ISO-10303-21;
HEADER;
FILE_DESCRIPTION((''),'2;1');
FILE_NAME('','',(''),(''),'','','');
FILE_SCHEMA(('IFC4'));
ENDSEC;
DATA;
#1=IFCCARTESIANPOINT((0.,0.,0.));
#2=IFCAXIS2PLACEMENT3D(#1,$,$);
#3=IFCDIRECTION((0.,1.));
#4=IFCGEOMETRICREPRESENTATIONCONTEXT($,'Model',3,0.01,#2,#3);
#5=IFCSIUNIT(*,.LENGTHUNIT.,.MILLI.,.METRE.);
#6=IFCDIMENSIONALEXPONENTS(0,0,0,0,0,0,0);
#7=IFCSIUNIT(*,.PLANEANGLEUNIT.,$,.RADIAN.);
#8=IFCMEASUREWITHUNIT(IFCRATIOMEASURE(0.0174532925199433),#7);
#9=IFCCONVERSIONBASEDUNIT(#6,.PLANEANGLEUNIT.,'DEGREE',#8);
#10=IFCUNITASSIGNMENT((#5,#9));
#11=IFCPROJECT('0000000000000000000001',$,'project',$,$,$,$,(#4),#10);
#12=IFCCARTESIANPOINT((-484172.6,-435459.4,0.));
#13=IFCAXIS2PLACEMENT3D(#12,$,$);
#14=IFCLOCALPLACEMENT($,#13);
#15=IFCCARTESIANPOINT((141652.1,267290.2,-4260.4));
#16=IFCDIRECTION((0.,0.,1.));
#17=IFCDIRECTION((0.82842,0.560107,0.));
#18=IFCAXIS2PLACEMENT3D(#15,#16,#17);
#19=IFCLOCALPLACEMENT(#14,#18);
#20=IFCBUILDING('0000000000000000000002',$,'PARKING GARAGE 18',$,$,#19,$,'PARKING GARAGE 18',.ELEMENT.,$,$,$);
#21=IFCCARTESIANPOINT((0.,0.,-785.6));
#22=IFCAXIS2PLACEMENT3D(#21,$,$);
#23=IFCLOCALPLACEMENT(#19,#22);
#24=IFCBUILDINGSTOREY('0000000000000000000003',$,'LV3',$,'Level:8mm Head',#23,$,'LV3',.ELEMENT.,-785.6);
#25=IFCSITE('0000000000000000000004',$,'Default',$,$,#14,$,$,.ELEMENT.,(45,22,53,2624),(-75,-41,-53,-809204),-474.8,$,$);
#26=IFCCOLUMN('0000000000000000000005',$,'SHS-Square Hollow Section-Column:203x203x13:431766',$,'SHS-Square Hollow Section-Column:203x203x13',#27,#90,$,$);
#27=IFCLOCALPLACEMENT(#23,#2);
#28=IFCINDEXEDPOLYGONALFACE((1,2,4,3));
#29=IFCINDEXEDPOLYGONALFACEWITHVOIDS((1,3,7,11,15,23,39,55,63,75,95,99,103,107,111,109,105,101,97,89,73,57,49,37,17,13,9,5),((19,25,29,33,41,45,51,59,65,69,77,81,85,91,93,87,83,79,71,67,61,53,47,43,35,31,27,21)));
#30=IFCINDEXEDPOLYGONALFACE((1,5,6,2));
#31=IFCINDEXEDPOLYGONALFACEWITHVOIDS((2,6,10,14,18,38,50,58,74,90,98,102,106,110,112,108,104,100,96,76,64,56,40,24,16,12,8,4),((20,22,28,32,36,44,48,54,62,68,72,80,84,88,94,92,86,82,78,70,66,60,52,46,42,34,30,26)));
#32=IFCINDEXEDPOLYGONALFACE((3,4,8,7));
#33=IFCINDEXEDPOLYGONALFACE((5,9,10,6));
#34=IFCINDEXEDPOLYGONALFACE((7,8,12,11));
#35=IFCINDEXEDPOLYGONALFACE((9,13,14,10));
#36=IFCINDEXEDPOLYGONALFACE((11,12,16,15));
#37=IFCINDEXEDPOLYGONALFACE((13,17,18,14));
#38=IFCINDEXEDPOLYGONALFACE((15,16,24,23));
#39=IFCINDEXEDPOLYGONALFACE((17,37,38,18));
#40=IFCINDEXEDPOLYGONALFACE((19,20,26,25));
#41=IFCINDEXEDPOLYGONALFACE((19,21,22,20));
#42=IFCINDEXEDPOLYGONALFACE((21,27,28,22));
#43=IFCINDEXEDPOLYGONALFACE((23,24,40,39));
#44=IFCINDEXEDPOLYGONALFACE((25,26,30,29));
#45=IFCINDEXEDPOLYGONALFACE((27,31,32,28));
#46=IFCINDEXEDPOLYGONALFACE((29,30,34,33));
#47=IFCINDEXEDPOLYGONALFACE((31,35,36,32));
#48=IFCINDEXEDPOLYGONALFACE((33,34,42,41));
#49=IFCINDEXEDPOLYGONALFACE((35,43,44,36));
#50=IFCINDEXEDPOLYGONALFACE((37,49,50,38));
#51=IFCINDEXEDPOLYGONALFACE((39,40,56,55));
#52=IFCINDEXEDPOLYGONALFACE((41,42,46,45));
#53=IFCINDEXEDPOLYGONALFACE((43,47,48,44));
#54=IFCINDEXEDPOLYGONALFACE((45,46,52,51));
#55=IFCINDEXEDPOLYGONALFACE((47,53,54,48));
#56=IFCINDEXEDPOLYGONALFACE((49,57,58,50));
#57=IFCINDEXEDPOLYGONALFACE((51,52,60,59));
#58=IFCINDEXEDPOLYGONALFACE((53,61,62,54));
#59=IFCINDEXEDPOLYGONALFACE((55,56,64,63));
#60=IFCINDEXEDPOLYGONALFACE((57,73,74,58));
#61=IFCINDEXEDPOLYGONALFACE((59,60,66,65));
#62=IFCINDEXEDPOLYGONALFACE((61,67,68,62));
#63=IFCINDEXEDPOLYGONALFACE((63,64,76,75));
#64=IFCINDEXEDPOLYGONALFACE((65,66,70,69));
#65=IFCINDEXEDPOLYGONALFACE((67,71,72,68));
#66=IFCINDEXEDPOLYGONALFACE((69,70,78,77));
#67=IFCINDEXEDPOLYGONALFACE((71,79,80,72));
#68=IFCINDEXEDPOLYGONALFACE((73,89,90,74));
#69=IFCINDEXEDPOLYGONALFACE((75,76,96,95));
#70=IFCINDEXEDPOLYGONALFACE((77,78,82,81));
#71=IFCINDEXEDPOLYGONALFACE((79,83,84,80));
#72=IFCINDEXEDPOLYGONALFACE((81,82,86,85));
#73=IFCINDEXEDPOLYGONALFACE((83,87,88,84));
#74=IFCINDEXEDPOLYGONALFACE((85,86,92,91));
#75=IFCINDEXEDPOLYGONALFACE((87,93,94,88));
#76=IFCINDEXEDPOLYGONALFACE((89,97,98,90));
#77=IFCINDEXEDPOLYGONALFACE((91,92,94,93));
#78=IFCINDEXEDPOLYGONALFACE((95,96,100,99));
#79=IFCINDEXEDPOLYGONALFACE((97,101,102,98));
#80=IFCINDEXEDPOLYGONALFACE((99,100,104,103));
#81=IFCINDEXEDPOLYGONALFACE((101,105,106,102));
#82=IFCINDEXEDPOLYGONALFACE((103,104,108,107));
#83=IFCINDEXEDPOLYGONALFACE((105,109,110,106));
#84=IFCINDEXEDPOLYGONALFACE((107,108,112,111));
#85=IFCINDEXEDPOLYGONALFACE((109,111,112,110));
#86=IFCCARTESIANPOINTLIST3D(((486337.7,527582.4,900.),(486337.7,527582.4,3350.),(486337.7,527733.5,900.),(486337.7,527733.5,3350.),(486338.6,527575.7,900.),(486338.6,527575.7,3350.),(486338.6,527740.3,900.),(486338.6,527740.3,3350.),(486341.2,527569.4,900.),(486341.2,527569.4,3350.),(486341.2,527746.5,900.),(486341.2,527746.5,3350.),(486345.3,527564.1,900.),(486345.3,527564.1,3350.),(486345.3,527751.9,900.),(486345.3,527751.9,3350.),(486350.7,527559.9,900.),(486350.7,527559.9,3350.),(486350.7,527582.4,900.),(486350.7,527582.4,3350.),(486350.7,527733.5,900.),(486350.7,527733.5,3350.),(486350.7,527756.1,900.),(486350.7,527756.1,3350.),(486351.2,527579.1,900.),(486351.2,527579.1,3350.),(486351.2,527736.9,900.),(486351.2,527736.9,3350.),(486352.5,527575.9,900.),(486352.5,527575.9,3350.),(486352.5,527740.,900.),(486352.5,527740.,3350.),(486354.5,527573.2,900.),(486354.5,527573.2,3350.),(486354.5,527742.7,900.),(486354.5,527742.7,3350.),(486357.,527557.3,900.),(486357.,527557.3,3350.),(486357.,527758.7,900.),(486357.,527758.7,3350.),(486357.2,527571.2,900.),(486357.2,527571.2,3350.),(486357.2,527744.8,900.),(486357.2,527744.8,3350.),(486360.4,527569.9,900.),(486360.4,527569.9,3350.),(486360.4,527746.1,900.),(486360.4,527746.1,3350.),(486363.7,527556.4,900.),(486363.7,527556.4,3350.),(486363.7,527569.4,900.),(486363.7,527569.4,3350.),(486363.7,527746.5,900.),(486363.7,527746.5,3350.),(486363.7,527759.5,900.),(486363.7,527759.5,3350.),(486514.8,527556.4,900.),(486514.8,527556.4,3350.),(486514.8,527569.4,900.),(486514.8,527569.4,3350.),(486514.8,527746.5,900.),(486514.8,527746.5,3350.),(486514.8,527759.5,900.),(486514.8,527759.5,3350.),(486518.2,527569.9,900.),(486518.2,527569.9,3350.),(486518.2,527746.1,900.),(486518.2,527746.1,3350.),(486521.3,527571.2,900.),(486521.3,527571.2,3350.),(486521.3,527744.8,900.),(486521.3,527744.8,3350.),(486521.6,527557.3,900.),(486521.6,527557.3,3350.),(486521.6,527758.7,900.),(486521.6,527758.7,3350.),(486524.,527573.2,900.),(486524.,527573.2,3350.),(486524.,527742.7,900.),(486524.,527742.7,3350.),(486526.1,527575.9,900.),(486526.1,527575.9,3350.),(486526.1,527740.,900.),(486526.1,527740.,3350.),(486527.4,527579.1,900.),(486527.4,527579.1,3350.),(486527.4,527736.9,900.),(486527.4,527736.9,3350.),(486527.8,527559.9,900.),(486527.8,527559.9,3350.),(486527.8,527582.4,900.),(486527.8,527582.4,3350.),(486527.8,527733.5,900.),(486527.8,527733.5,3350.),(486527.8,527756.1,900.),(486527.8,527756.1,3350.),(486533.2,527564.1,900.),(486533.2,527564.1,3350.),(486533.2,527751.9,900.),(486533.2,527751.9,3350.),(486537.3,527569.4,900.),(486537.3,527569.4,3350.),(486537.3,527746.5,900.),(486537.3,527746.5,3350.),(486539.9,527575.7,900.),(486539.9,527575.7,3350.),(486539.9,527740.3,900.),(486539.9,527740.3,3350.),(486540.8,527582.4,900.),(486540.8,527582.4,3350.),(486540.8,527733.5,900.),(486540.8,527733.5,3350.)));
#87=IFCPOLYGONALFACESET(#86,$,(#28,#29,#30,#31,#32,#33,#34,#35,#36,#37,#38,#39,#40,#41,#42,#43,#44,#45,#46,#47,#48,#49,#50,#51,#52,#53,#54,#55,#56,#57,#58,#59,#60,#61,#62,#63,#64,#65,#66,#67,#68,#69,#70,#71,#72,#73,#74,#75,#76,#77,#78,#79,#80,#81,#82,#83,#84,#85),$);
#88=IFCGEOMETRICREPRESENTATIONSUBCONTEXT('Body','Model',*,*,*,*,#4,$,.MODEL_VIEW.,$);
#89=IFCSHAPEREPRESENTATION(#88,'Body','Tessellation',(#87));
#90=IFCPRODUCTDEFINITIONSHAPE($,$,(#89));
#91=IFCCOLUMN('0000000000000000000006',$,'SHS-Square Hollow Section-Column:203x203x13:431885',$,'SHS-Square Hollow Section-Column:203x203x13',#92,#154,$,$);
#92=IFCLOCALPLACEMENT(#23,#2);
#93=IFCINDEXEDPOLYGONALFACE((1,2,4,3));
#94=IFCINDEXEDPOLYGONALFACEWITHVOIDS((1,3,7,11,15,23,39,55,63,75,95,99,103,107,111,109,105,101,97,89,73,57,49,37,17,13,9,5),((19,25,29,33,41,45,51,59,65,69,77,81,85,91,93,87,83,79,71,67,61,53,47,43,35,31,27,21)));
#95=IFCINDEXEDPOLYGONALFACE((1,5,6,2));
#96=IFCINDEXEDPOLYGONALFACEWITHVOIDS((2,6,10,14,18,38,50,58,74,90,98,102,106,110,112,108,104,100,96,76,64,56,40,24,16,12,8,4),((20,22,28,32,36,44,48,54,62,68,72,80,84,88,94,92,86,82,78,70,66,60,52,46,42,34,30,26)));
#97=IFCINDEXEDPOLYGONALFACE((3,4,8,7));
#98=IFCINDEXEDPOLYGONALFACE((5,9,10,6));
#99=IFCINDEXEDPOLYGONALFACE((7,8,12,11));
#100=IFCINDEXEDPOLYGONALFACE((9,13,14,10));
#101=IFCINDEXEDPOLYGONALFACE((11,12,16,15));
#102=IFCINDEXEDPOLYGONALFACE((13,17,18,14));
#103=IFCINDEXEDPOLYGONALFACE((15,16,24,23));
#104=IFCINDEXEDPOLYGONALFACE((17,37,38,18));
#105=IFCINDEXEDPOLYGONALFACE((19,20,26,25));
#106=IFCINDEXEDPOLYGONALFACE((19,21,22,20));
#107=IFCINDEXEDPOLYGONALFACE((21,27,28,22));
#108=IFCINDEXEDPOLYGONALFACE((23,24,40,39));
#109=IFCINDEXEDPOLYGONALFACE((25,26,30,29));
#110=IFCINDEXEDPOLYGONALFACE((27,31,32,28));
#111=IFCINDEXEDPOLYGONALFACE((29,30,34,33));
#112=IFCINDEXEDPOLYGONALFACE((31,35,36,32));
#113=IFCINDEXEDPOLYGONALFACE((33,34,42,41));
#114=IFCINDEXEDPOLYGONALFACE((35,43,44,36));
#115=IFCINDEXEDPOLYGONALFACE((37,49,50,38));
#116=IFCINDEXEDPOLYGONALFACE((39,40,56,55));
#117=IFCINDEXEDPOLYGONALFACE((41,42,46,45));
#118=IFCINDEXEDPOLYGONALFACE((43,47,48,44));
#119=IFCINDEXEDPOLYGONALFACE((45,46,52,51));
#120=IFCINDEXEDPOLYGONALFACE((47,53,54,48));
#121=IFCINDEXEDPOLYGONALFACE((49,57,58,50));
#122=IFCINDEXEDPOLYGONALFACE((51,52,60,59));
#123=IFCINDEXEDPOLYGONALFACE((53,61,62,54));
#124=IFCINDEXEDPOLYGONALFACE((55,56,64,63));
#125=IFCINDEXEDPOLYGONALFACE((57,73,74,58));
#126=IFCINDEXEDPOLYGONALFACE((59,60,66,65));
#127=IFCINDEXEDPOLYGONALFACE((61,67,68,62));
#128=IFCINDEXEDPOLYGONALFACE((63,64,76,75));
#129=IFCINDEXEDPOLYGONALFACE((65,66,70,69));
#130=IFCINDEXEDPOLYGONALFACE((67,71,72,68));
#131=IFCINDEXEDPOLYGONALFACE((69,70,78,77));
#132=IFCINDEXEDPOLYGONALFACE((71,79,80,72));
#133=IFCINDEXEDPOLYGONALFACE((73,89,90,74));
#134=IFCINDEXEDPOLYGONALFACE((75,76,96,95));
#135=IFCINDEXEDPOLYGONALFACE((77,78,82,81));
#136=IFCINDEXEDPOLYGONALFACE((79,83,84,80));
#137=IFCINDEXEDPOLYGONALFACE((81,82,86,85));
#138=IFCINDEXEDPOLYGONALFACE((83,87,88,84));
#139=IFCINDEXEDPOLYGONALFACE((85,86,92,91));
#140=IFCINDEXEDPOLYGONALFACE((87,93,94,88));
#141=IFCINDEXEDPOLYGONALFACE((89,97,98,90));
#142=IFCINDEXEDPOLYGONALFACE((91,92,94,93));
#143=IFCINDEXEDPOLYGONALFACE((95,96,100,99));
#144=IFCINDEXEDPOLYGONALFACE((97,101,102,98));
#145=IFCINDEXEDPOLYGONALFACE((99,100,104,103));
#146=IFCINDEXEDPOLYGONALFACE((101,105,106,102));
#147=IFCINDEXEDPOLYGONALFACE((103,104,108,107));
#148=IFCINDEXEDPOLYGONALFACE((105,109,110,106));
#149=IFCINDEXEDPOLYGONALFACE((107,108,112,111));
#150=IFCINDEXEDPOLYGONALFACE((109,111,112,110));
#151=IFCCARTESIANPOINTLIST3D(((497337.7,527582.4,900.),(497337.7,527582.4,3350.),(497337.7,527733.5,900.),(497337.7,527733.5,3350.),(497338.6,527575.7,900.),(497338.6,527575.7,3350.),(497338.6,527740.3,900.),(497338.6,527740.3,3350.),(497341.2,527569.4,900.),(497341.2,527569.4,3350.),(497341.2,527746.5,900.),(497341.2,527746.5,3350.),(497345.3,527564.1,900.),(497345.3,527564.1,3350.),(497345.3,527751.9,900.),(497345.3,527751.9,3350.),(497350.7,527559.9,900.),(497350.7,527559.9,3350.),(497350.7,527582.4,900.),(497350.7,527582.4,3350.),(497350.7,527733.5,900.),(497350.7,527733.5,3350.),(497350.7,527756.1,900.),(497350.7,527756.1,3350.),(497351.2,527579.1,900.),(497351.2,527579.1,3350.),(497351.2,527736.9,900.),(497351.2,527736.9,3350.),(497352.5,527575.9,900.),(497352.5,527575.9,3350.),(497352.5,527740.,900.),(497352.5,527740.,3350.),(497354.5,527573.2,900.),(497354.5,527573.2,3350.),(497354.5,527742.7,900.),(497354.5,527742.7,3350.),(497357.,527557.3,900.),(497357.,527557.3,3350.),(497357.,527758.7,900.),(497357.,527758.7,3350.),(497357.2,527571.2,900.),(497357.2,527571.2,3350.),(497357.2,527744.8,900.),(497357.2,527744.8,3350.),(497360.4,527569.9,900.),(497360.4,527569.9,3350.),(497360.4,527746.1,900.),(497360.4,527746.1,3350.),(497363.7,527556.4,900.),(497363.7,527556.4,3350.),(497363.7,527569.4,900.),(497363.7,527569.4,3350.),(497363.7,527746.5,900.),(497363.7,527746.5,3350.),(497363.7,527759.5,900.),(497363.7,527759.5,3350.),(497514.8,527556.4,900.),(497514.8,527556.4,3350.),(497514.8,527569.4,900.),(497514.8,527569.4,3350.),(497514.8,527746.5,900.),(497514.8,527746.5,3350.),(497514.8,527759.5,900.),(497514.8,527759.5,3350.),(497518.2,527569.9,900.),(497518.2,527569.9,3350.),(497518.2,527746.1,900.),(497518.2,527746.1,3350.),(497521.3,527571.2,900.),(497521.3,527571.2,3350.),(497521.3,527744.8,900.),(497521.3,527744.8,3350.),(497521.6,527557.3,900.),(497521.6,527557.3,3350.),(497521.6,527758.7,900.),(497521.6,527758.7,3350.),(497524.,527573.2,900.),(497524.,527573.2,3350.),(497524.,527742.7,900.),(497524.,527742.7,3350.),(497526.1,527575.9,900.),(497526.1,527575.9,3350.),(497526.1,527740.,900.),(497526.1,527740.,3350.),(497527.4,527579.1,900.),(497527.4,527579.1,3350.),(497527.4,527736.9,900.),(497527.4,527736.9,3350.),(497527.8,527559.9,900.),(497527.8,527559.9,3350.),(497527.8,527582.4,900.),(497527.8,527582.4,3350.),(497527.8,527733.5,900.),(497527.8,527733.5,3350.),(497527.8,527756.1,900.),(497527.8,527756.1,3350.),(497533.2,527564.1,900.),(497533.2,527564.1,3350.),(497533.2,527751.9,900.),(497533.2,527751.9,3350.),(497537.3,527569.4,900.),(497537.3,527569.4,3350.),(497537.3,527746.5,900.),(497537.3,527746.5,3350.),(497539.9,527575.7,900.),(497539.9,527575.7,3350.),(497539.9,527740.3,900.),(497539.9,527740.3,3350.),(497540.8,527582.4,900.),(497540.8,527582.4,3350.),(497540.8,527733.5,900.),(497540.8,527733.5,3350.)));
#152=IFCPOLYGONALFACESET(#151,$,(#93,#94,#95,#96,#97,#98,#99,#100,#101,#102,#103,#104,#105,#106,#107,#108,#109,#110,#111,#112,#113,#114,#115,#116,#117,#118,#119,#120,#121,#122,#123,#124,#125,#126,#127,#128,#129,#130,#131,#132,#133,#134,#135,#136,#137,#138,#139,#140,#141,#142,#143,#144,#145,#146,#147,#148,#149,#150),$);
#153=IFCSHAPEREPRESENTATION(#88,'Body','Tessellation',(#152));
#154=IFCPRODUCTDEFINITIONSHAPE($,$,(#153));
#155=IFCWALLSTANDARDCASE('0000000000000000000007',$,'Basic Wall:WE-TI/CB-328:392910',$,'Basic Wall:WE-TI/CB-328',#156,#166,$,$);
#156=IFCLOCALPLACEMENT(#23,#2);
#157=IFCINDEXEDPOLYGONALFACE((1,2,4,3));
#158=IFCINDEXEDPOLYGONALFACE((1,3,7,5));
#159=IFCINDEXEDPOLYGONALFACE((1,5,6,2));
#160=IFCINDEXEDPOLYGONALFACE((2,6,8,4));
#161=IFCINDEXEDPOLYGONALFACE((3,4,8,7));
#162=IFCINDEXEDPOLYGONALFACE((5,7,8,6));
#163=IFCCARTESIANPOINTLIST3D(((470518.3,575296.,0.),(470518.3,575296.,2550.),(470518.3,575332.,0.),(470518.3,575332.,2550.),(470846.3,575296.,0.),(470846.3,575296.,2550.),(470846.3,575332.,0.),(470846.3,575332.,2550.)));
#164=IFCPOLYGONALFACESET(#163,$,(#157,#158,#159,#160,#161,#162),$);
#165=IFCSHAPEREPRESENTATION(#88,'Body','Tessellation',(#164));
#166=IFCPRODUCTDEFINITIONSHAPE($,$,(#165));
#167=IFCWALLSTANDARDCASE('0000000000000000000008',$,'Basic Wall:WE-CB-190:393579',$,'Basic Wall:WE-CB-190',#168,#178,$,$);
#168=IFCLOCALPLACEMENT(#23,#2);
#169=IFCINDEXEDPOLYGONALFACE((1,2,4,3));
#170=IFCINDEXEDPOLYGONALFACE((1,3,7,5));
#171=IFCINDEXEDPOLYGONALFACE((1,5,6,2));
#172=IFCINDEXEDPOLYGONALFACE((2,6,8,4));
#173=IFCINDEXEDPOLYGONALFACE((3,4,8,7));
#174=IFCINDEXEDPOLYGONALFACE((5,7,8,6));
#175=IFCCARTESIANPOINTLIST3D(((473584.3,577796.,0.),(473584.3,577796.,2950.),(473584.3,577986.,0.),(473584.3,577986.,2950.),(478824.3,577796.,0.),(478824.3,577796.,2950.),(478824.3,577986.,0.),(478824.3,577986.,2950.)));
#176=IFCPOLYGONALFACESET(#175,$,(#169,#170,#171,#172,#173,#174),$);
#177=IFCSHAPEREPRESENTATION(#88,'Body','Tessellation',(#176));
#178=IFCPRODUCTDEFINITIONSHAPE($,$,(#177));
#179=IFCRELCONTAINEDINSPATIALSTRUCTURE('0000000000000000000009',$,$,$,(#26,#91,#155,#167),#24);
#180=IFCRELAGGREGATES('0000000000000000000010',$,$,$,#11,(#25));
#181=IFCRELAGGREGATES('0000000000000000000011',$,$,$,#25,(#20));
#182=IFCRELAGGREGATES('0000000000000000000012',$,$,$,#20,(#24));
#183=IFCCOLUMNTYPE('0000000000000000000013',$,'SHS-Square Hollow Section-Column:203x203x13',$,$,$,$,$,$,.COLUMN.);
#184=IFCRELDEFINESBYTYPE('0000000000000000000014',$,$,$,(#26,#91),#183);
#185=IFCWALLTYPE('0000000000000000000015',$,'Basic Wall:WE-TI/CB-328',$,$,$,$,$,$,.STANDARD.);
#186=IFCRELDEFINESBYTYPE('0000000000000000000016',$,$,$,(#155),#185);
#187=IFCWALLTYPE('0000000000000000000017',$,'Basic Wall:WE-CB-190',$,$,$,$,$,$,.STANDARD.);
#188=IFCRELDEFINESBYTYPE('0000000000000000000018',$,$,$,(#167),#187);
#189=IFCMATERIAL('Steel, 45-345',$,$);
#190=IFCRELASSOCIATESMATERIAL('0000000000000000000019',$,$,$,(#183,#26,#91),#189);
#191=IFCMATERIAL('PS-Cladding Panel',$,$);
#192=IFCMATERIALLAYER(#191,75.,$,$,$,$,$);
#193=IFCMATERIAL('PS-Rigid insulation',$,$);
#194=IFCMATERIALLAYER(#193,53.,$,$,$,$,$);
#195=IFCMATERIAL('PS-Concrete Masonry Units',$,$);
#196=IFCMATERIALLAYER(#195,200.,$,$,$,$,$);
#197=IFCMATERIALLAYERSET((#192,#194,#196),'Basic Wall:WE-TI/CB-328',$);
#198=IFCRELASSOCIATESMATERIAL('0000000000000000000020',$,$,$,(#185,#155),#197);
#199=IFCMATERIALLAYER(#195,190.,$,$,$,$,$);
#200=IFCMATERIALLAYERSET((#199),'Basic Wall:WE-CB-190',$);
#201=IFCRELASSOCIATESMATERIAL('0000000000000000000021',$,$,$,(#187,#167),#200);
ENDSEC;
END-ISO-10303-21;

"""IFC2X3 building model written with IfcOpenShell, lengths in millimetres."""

from ifc_helpers import new_model, entity, si_unit, converted_unit, direction, frame, frame_2d, origin, place, context, subcontext, project, spatial, polyline, circle_curve, parameter, trimmed, segment, composite_curve, rectangle, outline, extrude, source, transform, mapped, material, layer, layer_set, layer_usage, type_object, type_shapes, element, save


model = new_model("IFC2X3")

# Units and contexts
model_context = context("Model", 3, precision=0.01, world=origin(), true_north=direction((0.0, 1.0)))
body_context = subcontext(model_context, "Body", "Model", "MODEL_VIEW")
ifc_project = project(units=[si_unit("LENGTHUNIT", "METRE", prefix="MILLI"), converted_unit("PLANEANGLEUNIT", "DEGREE", entity("IfcRatioMeasure", 0.0174532925199433), si_unit("PLANEANGLEUNIT", "RADIAN"), dimensions=[0, 0, 0, 0, 0, 0, 0])], contexts=[model_context])

# Site, building, storey
site_placement = place(None, frame((-484172.6, -435459.4, 0.0)))
site = spatial("IfcSite", under=ifc_project, at=site_placement, Name="Default", CompositionType="ELEMENT", RefLatitude=(45, 22, 53, 2624), RefLongitude=(-75, -41, -53, -809204), RefElevation=-474.8)
building_placement = place(site_placement, frame((141652.1, 267290.2, -4260.4), z_axis=(0.0, 0.0, 1.0), x_axis=(0.82842, 0.560107, 0.0)))
building = spatial("IfcBuilding", under=site, at=building_placement, Name="PARKING GARAGE 18", LongName="PARKING GARAGE 18", CompositionType="ELEMENT")
storey_placement = place(building_placement, frame((0.0, 0.0, -785.6)))
storey = spatial("IfcBuildingStorey", under=building, at=storey_placement, Name="LV3", ObjectType="Level:8mm Head", LongName="LV3", CompositionType="ELEMENT", Elevation=-785.6)

# Columns
ifc_material_1 = material(Name="Steel, 45-345")
column_type_1 = type_object("IfcColumnType", Name="SHS-Square Hollow Section-Column:203x203x13", PredefinedType="COLUMN", material=ifc_material_1)
shared_shape_1 = source(origin(), body_context, "Body", "SweptSolid", [
    extrude(outline(composite_curve([segment(polyline([(-75.6, -101.5), (75.6, -101.5)]), True, "CONTINUOUS"), segment(trimmed(circle_curve(frame_2d((75.6, -75.6), x_axis=(-1.0, 0.0)), 26.0), [parameter(90.0)], [parameter(180.0)], True, "PARAMETER"), True, "CONTINUOUS"), segment(polyline([(101.5, -75.6), (101.5, 75.6)]), True, "CONTINUOUS"), segment(trimmed(circle_curve(frame_2d((75.5, 75.6), x_axis=(-1.0, 0.0)), 26.0), [parameter(180.0)], [parameter(270.0)], True, "PARAMETER"), True, "CONTINUOUS"), segment(polyline([(75.5, 101.6), (-75.5, 101.6)]), True, "CONTINUOUS"), segment(trimmed(circle_curve(frame_2d((-75.5, 75.5), x_axis=(-1.0, 0.0)), 26.0), [parameter(270.0)], [parameter(360.0)], True, "PARAMETER"), True, "CONTINUOUS"), segment(polyline([(-101.5, 75.5), (-101.5, -75.6)]), True, "CONTINUOUS"), segment(trimmed(circle_curve(frame_2d((-75.6, -75.6), x_axis=(-1.0, 0.0)), 26.0), [parameter(360.0)], [parameter(90.0)], True, "PARAMETER"), True, "CONTINUOUS")], self_intersect=False), holes=[composite_curve([segment(trimmed(circle_curve(frame_2d((-75.6, -75.6), x_axis=(-1.0, 0.0)), 13.0), [parameter(0.0)], [parameter(90.0)], True, "PARAMETER"), False, "CONTINUOUS"), segment(polyline([(-88.5, -75.6), (-88.5, 75.6)]), True, "CONTINUOUS"), segment(trimmed(circle_curve(frame_2d((-75.6, 75.6), x_axis=(-1.0, 0.0)), 13.0), [parameter(270.0)], [parameter(0.0)], True, "PARAMETER"), False, "CONTINUOUS"), segment(polyline([(-75.6, 88.6), (75.5, 88.6)]), True, "CONTINUOUS"), segment(trimmed(circle_curve(frame_2d((75.5, 75.5), x_axis=(-1.0, 0.0)), 13.0), [parameter(180.0)], [parameter(270.0)], True, "PARAMETER"), False, "CONTINUOUS"), segment(polyline([(88.6, 75.5), (88.6, -75.5)]), True, "CONTINUOUS"), segment(trimmed(circle_curve(frame_2d((75.6, -75.5), x_axis=(-1.0, 0.0)), 13.0), [parameter(90.0)], [parameter(180.0)], True, "PARAMETER"), False, "CONTINUOUS"), segment(polyline([(75.6, -88.5), (-75.6, -88.5)]), True, "CONTINUOUS")], self_intersect=False)]), frame((0.0, 0.0, 114.4), z_axis=(0.0, 0.0, 1.0), x_axis=(-1.0, 0.0, 0.0)), (0.0, 0.0, 1.0), 2450.0),
])
type_shapes(column_type_1, [shared_shape_1])
for number, where, name in (
    (1, (486439.3, 527658.0, 785.6), "SHS-Square Hollow Section-Column:203x203x13:431766"),
    (2, (497439.3, 527658.0, 785.6), "SHS-Square Hollow Section-Column:203x203x13:431885"),
):
    element("IfcColumn", number, at=place(storey_placement, frame(where)), inside=storey, type_object=column_type_1, material=ifc_material_1, Name=name, ObjectType="SHS-Square Hollow Section-Column:203x203x13", context=body_context, shape_type="MappedRepresentation", body=[
        mapped(shared_shape_1, transform((0.0, 0.0, 0.0), scale=1.0)),
    ])

# Walls
ifc_material_2 = material(Name="PS-Cladding Panel")
ifc_layer_1 = layer(ifc_material_2, 75.0)
ifc_material_3 = material(Name="PS-Rigid insulation")
ifc_layer_2 = layer(ifc_material_3, 53.0)
ifc_material_4 = material(Name="PS-Concrete Masonry Units")
ifc_layer_3 = layer(ifc_material_4, 200.0)
ifc_layer_set_1 = layer_set([ifc_layer_1, ifc_layer_2, ifc_layer_3], Name="Basic Wall:WE-TI/CB-328")
wall_type_1 = type_object("IfcWallType", Name="Basic Wall:WE-TI/CB-328", PredefinedType="STANDARD", material=ifc_layer_set_1)
ifc_layer_usage_1 = layer_usage(ifc_layer_set_1, "AXIS2", "POSITIVE", -164.0)
wall_1_placement = place(storey_placement, frame((470682.3, 575332.0, 0.0), z_axis=(0.0, 0.0, 1.0), x_axis=(0.0, -1.0, 0.0)))
element("IfcWallStandardCase", 3, at=wall_1_placement, inside=storey, type_object=wall_type_1, material=ifc_layer_usage_1, Name="Basic Wall:WE-TI/CB-328:392910", ObjectType="Basic Wall:WE-TI/CB-328", context=body_context, shape_type="SweptSolid", body=[
    extrude(rectangle(XDim=36.0, YDim=328.0, at=frame_2d((18.0, 0.0), x_axis=(-1.0, 0.0))), origin(), (0.0, 0.0, 1.0), 2550.0),
])
ifc_layer_4 = layer(ifc_material_4, 190.0)
ifc_layer_set_2 = layer_set([ifc_layer_4], Name="Basic Wall:WE-CB-190")
ifc_layer_usage_2 = layer_usage(ifc_layer_set_2, "AXIS2", "NEGATIVE", 95.0)
wall_type_2 = type_object("IfcWallType", Name="Basic Wall:WE-CB-190", PredefinedType="STANDARD", material=ifc_layer_set_2)
wall_2_placement = place(storey_placement, frame((473584.3, 577891.0, 0.0)))
element("IfcWallStandardCase", 4, at=wall_2_placement, inside=storey, type_object=wall_type_2, material=ifc_layer_usage_2, Name="Basic Wall:WE-CB-190:393579", ObjectType="Basic Wall:WE-CB-190", context=body_context, shape_type="SweptSolid", body=[
    extrude(rectangle(XDim=5240.0, YDim=190.0, at=frame_2d((2620.0, 0.0), x_axis=(-1.0, 0.0))), origin(), (0.0, 0.0, 1.0), 2950.0),
])

save(model, "model.ifc")
